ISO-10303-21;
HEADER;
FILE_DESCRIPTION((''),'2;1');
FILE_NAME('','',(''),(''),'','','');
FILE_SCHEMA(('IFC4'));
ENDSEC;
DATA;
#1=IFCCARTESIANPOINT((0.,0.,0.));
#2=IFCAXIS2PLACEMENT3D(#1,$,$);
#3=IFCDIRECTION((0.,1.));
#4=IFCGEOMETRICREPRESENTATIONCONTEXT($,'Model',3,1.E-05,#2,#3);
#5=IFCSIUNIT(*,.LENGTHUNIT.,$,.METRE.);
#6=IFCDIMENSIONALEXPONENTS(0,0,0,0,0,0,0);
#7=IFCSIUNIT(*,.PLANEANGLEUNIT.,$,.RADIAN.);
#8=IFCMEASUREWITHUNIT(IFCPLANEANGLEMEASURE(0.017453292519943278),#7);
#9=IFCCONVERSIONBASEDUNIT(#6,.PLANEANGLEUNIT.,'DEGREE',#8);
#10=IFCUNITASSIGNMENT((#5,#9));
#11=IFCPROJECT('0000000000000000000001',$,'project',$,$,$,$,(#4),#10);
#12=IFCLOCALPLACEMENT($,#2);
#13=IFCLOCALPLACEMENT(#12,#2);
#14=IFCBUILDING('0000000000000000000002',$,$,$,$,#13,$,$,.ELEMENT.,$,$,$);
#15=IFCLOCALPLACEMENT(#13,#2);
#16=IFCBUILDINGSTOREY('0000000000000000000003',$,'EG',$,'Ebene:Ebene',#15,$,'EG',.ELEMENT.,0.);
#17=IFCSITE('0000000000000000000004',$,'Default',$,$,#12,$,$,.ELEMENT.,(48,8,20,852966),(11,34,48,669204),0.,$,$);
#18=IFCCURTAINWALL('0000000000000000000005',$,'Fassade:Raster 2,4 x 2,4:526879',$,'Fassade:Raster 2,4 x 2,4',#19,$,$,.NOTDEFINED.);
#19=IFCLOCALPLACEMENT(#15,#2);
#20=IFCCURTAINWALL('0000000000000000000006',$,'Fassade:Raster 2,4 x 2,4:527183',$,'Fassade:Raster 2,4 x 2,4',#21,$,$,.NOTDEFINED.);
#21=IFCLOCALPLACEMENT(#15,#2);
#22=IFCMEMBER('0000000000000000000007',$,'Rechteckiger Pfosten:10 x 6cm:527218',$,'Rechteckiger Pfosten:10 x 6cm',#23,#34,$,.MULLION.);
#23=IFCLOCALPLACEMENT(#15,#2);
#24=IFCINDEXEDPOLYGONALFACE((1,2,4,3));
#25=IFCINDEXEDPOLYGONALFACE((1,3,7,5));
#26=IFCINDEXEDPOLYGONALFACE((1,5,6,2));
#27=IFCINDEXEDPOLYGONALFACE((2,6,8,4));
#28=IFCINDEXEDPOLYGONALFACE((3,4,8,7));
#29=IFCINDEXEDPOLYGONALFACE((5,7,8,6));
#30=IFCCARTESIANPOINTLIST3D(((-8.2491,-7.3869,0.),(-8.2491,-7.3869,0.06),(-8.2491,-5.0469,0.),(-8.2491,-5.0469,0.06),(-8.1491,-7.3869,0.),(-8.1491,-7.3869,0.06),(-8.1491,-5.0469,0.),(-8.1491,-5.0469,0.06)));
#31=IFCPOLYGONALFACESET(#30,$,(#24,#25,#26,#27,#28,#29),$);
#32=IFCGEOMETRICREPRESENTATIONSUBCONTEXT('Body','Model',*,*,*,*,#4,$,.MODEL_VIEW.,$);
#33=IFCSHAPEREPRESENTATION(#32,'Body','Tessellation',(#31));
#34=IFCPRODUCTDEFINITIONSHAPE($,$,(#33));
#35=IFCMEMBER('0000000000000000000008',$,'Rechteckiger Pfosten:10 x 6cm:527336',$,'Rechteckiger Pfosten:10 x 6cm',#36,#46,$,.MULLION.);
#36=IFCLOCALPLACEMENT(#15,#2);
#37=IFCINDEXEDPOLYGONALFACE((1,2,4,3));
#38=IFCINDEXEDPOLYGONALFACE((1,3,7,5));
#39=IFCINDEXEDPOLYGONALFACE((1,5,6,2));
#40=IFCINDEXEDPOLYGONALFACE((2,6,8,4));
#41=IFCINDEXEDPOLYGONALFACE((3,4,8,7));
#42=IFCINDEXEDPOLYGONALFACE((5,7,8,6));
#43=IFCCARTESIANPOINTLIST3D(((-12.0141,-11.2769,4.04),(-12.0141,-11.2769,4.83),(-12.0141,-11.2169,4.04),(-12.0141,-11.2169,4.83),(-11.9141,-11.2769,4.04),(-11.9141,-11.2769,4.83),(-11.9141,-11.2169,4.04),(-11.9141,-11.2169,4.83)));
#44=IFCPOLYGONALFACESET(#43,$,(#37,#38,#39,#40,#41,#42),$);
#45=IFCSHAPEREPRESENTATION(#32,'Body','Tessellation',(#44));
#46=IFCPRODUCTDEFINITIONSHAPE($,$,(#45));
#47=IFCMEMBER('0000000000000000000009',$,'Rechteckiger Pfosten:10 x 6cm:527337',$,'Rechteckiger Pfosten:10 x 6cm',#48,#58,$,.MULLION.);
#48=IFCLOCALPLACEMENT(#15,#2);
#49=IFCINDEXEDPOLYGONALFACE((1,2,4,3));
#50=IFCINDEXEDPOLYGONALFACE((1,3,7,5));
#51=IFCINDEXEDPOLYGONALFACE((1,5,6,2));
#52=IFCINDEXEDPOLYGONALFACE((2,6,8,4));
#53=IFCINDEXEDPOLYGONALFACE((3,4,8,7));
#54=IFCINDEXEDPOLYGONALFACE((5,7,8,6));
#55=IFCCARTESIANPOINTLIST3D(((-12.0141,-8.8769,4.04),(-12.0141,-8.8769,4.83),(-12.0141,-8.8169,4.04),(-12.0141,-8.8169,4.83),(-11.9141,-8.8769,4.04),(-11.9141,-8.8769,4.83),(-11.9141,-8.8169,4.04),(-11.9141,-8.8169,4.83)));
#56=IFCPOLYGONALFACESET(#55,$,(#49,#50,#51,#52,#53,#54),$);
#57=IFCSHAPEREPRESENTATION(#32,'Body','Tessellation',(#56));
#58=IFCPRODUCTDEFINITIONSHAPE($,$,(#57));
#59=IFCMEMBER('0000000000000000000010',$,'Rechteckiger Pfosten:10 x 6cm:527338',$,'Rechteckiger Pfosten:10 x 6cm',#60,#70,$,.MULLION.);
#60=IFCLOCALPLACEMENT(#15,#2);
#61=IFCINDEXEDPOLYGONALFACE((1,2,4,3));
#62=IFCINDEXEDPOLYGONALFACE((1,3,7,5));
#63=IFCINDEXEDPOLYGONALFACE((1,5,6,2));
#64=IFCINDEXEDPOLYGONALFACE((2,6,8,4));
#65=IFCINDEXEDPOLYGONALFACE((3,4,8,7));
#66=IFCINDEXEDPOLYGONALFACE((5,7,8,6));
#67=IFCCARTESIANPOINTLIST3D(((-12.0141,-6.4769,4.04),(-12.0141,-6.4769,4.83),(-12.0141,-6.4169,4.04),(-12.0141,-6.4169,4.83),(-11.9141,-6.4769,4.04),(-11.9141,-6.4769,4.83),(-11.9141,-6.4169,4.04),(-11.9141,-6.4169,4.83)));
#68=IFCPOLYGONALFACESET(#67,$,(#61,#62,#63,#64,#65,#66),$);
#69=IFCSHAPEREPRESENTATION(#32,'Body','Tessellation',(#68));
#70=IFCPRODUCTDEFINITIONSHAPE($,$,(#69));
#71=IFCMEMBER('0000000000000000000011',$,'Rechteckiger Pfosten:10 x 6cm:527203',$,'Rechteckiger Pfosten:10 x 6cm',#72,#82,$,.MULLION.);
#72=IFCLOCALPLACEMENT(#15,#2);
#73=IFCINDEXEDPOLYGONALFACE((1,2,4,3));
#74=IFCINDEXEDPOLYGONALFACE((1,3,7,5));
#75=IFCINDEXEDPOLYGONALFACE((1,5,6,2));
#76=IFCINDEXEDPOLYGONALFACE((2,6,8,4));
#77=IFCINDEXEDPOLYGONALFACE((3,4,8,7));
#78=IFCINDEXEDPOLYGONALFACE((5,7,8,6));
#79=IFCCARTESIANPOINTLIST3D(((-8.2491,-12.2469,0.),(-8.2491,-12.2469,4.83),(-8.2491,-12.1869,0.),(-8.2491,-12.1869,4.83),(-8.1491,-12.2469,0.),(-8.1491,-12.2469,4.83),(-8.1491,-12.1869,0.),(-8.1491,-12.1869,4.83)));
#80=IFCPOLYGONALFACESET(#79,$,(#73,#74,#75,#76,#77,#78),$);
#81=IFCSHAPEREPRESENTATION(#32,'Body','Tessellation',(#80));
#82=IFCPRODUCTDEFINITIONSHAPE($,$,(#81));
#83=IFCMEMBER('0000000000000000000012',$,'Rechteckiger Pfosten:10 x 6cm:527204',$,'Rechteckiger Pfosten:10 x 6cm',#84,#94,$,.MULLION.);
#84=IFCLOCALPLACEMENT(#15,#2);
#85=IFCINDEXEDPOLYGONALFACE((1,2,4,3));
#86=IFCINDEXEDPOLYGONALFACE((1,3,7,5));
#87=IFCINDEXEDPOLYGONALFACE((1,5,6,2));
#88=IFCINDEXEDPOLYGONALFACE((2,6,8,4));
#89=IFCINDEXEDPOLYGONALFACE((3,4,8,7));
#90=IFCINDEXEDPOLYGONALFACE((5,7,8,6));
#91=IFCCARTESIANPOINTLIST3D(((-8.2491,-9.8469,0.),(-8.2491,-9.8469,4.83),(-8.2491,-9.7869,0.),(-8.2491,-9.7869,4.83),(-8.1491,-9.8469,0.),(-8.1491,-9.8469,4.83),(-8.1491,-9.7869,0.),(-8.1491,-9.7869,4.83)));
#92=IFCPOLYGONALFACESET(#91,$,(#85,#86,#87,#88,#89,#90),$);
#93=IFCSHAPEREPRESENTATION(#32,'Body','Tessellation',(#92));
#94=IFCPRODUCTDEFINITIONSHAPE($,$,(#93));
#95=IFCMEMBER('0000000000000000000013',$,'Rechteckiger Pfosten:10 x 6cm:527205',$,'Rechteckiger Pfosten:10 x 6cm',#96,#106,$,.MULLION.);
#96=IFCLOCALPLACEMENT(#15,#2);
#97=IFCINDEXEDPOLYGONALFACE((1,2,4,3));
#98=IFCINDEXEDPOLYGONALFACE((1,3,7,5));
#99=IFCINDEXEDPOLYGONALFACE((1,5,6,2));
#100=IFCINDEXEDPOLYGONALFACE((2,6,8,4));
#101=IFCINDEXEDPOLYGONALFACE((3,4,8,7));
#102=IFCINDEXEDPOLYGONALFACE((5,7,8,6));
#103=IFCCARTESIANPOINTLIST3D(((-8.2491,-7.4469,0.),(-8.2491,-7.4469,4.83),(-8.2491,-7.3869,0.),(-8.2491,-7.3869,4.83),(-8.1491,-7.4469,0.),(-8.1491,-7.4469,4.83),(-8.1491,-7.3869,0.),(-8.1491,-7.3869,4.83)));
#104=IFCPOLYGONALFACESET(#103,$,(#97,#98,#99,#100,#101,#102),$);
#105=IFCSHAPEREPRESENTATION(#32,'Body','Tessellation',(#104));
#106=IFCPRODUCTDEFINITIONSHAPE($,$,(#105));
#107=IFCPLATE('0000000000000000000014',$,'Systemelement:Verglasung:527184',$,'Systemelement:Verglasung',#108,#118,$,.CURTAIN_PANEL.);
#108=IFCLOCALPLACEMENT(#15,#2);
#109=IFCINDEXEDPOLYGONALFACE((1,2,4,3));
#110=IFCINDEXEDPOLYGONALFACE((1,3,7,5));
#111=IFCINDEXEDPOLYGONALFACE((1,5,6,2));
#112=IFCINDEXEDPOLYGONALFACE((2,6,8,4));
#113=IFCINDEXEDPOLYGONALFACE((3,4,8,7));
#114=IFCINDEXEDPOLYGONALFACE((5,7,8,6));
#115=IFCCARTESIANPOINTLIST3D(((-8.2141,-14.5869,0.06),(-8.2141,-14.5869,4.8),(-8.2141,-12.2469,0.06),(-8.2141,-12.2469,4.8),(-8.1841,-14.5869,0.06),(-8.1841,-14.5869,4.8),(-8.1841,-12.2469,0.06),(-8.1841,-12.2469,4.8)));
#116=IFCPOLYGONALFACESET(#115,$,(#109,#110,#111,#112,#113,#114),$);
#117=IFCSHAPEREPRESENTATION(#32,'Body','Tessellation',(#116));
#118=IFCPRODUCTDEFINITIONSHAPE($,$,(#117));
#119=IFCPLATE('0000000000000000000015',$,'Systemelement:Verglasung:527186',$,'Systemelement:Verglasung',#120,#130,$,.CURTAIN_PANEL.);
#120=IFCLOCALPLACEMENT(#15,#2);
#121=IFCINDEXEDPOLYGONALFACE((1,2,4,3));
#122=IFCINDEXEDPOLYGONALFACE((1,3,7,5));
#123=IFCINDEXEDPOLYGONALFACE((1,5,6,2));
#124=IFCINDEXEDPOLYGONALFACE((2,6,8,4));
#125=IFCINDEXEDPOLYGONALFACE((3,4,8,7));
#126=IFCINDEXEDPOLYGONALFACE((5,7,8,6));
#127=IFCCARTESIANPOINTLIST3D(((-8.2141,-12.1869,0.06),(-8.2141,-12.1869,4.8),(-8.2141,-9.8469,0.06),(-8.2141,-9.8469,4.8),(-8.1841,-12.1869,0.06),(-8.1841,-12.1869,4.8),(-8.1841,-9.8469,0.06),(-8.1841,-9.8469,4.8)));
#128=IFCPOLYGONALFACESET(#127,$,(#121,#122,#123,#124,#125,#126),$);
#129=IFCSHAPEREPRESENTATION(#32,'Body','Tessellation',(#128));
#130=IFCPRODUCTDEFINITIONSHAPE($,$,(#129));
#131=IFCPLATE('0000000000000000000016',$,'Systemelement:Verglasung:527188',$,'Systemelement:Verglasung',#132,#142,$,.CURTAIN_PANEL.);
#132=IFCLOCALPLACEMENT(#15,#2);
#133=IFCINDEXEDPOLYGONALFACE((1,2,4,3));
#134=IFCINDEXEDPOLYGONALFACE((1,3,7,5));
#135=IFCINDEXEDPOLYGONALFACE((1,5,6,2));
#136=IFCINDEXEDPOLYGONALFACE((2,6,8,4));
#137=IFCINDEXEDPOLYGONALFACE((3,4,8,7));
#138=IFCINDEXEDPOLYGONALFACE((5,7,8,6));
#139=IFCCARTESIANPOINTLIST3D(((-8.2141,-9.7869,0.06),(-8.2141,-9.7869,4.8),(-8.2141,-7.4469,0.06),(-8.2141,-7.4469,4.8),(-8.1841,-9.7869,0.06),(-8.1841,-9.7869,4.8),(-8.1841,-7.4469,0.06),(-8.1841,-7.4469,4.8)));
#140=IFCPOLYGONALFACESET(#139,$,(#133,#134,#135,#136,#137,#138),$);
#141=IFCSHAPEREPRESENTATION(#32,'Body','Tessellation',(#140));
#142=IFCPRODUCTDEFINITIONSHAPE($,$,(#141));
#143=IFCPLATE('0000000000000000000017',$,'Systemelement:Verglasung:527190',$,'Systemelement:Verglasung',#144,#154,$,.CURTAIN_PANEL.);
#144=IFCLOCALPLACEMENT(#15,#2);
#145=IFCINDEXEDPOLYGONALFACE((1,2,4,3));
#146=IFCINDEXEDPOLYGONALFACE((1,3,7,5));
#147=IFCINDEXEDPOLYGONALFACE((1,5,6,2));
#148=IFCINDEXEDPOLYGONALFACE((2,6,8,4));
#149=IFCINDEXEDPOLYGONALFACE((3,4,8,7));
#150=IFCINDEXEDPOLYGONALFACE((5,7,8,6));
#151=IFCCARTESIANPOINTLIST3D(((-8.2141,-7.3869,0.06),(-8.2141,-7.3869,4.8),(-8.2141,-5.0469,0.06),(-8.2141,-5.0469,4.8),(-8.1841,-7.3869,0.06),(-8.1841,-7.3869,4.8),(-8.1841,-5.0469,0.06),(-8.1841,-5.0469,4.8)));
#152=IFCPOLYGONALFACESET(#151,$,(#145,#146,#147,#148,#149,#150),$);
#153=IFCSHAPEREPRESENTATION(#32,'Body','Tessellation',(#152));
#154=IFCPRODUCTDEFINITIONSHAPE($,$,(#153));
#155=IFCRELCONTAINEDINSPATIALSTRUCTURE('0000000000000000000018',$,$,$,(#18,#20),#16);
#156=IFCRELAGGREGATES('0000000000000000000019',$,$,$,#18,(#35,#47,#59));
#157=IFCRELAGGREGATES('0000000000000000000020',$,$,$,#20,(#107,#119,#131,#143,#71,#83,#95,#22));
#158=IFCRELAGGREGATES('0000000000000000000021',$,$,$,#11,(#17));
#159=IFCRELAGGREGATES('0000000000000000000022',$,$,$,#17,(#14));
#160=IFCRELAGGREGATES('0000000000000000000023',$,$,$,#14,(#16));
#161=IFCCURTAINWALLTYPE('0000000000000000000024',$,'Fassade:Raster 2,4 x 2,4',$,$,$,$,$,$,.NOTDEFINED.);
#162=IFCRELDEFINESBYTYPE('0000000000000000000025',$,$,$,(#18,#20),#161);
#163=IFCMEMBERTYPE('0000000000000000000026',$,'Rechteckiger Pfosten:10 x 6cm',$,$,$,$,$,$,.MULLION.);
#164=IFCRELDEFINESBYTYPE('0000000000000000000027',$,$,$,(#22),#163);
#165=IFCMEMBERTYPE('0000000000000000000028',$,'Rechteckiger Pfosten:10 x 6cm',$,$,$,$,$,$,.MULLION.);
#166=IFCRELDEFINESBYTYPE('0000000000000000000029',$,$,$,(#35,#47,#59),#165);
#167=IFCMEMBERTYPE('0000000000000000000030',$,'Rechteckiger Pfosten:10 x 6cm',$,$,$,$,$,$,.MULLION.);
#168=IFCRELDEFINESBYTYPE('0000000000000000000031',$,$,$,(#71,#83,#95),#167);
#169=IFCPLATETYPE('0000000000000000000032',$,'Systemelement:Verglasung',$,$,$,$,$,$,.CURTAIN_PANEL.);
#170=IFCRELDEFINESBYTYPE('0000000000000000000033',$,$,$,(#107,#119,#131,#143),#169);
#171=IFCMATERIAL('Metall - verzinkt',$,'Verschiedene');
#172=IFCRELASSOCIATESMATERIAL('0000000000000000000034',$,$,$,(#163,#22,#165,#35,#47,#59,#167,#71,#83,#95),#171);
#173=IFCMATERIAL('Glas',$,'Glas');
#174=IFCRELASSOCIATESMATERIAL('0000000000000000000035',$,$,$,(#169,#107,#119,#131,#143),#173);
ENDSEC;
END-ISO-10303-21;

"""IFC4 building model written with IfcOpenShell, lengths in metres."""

from ifc_helpers import new_model, entity, si_unit, converted_unit, direction, frame, origin, place, context, subcontext, project, spatial, indexed_curve, outline, extrude, source, transform, mapped, material, type_object, type_shapes, element, aggregate, save


model = new_model("IFC4")

# Units and contexts
model_context = context("Model", 3, precision=1e-05, world=origin(), true_north=direction((0.0, 1.0)))
body_context = subcontext(model_context, "Body", "Model", "MODEL_VIEW")
ifc_project = project(units=[si_unit("LENGTHUNIT", "METRE"), converted_unit("PLANEANGLEUNIT", "DEGREE", entity("IfcPlaneAngleMeasure", 0.017453292519943278), si_unit("PLANEANGLEUNIT", "RADIAN"), dimensions=[0, 0, 0, 0, 0, 0, 0])], contexts=[model_context])

# Site, building, storey
site_placement = place(None, origin())
site = spatial("IfcSite", under=ifc_project, at=site_placement, Name="Default", CompositionType="ELEMENT", RefLatitude=(48, 8, 20, 852966), RefLongitude=(11, 34, 48, 669204), RefElevation=0.0)
building_placement = place(site_placement, origin())
building = spatial("IfcBuilding", under=site, at=building_placement, CompositionType="ELEMENT")
storey_placement = place(building_placement, origin())
storey = spatial("IfcBuildingStorey", under=building, at=storey_placement, Name="EG", ObjectType="Ebene:Ebene", LongName="EG", CompositionType="ELEMENT", Elevation=0.0)

# Curtain walls, member
curtain_wall_type = type_object("IfcCurtainWallType", Name="Fassade:Raster 2,4 x 2,4", PredefinedType="NOTDEFINED")
curtain_wall_1_placement = place(storey_placement, origin())
curtain_wall_1 = element("IfcCurtainWall", 1, at=curtain_wall_1_placement, inside=storey, type_object=curtain_wall_type, Name="Fassade:Raster 2,4 x 2,4:526879", ObjectType="Fassade:Raster 2,4 x 2,4", PredefinedType="NOTDEFINED")
ifc_material_1 = material(Name="Metall - verzinkt", Category="Verschiedene")
member_type_1 = type_object("IfcMemberType", Name="Rechteckiger Pfosten:10 x 6cm", PredefinedType="MULLION", material=ifc_material_1)
shared_shape_1 = source(origin(), body_context, "Body", "SweptSolid", [
    extrude(outline(indexed_curve([(-0.03, -0.05), (0.03, -0.05), (0.03, 0.05), (-0.03, 0.05), (-0.03, -0.05)], self_intersect=False)), frame((-0.03, 0.0, -2.34), z_axis=(0.0, 0.0, 1.0), x_axis=(-1.0, 0.0, 0.0)), (0.0, 0.0, 1.0), 2.34),
])
type_shapes(member_type_1, [shared_shape_1])
curtain_wall_2_placement = place(storey_placement, origin())
curtain_wall_2 = element("IfcCurtainWall", 2, at=curtain_wall_2_placement, inside=storey, type_object=curtain_wall_type, Name="Fassade:Raster 2,4 x 2,4:527183", ObjectType="Fassade:Raster 2,4 x 2,4", PredefinedType="NOTDEFINED")
member_1_placement = place(curtain_wall_2_placement, frame((-8.1991, -7.3869, 0.0), z_axis=(0.0, -1.0, 0.0), x_axis=(0.0, 0.0, -1.0)))
member_1 = element("IfcMember", 3, at=member_1_placement, type_object=member_type_1, material=ifc_material_1, Name="Rechteckiger Pfosten:10 x 6cm:527218", ObjectType="Rechteckiger Pfosten:10 x 6cm", PredefinedType="MULLION", context=body_context, shape_type="MappedRepresentation", body=[
    mapped(shared_shape_1, transform((0.0, 0.0, 0.0), scale=1.0)),
])

# Members
member_type_2 = type_object("IfcMemberType", Name="Rechteckiger Pfosten:10 x 6cm", PredefinedType="MULLION", material=ifc_material_1)
shared_shape_2 = source(origin(), body_context, "Body", "SweptSolid", [
    extrude(outline(indexed_curve([(-0.03, -0.05), (0.03, -0.05), (0.03, 0.05), (-0.03, 0.05), (-0.03, -0.05)], self_intersect=False)), frame((0.0, 0.0, -0.79), z_axis=(0.0, 0.0, 1.0), x_axis=(-1.0, 0.0, 0.0)), (0.0, 0.0, 1.0), 0.79),
])
type_shapes(member_type_2, [shared_shape_2])
member_2_placement = place(curtain_wall_1_placement, frame((-11.9641, -11.2469, 4.04), z_axis=(0.0, 0.0, -1.0), x_axis=(0.0, 1.0, 0.0)))
member_2 = element("IfcMember", 4, at=member_2_placement, type_object=member_type_2, material=ifc_material_1, Name="Rechteckiger Pfosten:10 x 6cm:527336", ObjectType="Rechteckiger Pfosten:10 x 6cm", PredefinedType="MULLION", context=body_context, shape_type="MappedRepresentation", body=[
    mapped(shared_shape_2, transform((0.0, 0.0, 0.0), scale=1.0)),
])
member_3_placement = place(curtain_wall_1_placement, frame((-11.9641, -8.8469, 4.04), z_axis=(0.0, 0.0, -1.0), x_axis=(0.0, 1.0, 0.0)))
member_3 = element("IfcMember", 5, at=member_3_placement, type_object=member_type_2, material=ifc_material_1, Name="Rechteckiger Pfosten:10 x 6cm:527337", ObjectType="Rechteckiger Pfosten:10 x 6cm", PredefinedType="MULLION", context=body_context, shape_type="MappedRepresentation", body=[
    mapped(shared_shape_2, transform((0.0, 0.0, 0.0), scale=1.0)),
])
member_4_placement = place(curtain_wall_1_placement, frame((-11.9641, -6.4469, 4.04), z_axis=(0.0, 0.0, -1.0), x_axis=(0.0, 1.0, 0.0)))
member_4 = element("IfcMember", 6, at=member_4_placement, type_object=member_type_2, material=ifc_material_1, Name="Rechteckiger Pfosten:10 x 6cm:527338", ObjectType="Rechteckiger Pfosten:10 x 6cm", PredefinedType="MULLION", context=body_context, shape_type="MappedRepresentation", body=[
    mapped(shared_shape_2, transform((0.0, 0.0, 0.0), scale=1.0)),
])
member_type_3 = type_object("IfcMemberType", Name="Rechteckiger Pfosten:10 x 6cm", PredefinedType="MULLION", material=ifc_material_1)
shared_shape_3 = source(origin(), body_context, "Body", "SweptSolid", [
    extrude(outline(indexed_curve([(-0.03, -0.05), (0.03, -0.05), (0.03, 0.05), (-0.03, 0.05), (-0.03, -0.05)], self_intersect=False)), frame((0.0, 0.0, -4.83), z_axis=(0.0, 0.0, 1.0), x_axis=(-1.0, 0.0, 0.0)), (0.0, 0.0, 1.0), 4.83),
])
type_shapes(member_type_3, [shared_shape_3])
member_5_placement = place(curtain_wall_2_placement, frame((-8.1991, -12.2169, 0.0), z_axis=(0.0, 0.0, -1.0), x_axis=(0.0, 1.0, 0.0)))
member_5 = element("IfcMember", 7, at=member_5_placement, type_object=member_type_3, material=ifc_material_1, Name="Rechteckiger Pfosten:10 x 6cm:527203", ObjectType="Rechteckiger Pfosten:10 x 6cm", PredefinedType="MULLION", context=body_context, shape_type="MappedRepresentation", body=[
    mapped(shared_shape_3, transform((0.0, 0.0, 0.0), scale=1.0)),
])
member_6_placement = place(curtain_wall_2_placement, frame((-8.1991, -9.8169, 0.0), z_axis=(0.0, 0.0, -1.0), x_axis=(0.0, 1.0, 0.0)))
member_6 = element("IfcMember", 8, at=member_6_placement, type_object=member_type_3, material=ifc_material_1, Name="Rechteckiger Pfosten:10 x 6cm:527204", ObjectType="Rechteckiger Pfosten:10 x 6cm", PredefinedType="MULLION", context=body_context, shape_type="MappedRepresentation", body=[
    mapped(shared_shape_3, transform((0.0, 0.0, 0.0), scale=1.0)),
])
member_7_placement = place(curtain_wall_2_placement, frame((-8.1991, -7.4169, 0.0), z_axis=(0.0, 0.0, -1.0), x_axis=(0.0, 1.0, 0.0)))
member_7 = element("IfcMember", 9, at=member_7_placement, type_object=member_type_3, material=ifc_material_1, Name="Rechteckiger Pfosten:10 x 6cm:527205", ObjectType="Rechteckiger Pfosten:10 x 6cm", PredefinedType="MULLION", context=body_context, shape_type="MappedRepresentation", body=[
    mapped(shared_shape_3, transform((0.0, 0.0, 0.0), scale=1.0)),
])

# Plates
ifc_material_2 = material(Name="Glas", Category="Glas")
aggregate(curtain_wall_1, [member_2, member_3, member_4])
plate_type_1 = type_object("IfcPlateType", Name="Systemelement:Verglasung", PredefinedType="CURTAIN_PANEL", material=ifc_material_2)
shared_shape_4 = source(origin(), body_context, "Body", "SweptSolid", [
    extrude(outline(indexed_curve([(-0.015, -1.17), (0.015, -1.17), (0.015, 1.17), (-0.015, 1.17), (-0.015, -1.17)], self_intersect=False)), frame((0.0, 0.0, 0.0), z_axis=(0.0, 0.0, 1.0), x_axis=(0.0, 1.0, 0.0)), (0.0, 0.0, 1.0), 4.74),
])
type_shapes(plate_type_1, [shared_shape_4])
plate_1_placement = place(curtain_wall_2_placement, frame((-8.1991, -13.4169, 0.06), z_axis=(0.0, 0.0, 1.0), x_axis=(0.0, 1.0, 0.0)))
plate_1 = element("IfcPlate", 10, at=plate_1_placement, type_object=plate_type_1, material=ifc_material_2, Name="Systemelement:Verglasung:527184", ObjectType="Systemelement:Verglasung", PredefinedType="CURTAIN_PANEL", context=body_context, shape_type="MappedRepresentation", body=[
    mapped(shared_shape_4, transform((0.0, 0.0, 0.0), scale=1.0)),
])
plate_2_placement = place(curtain_wall_2_placement, frame((-8.1991, -11.0169, 0.06), z_axis=(0.0, 0.0, 1.0), x_axis=(0.0, 1.0, 0.0)))
plate_2 = element("IfcPlate", 11, at=plate_2_placement, type_object=plate_type_1, material=ifc_material_2, Name="Systemelement:Verglasung:527186", ObjectType="Systemelement:Verglasung", PredefinedType="CURTAIN_PANEL", context=body_context, shape_type="MappedRepresentation", body=[
    mapped(shared_shape_4, transform((0.0, 0.0, 0.0), scale=1.0)),
])
plate_3_placement = place(curtain_wall_2_placement, frame((-8.1991, -8.6169, 0.06), z_axis=(0.0, 0.0, 1.0), x_axis=(0.0, 1.0, 0.0)))
plate_3 = element("IfcPlate", 12, at=plate_3_placement, type_object=plate_type_1, material=ifc_material_2, Name="Systemelement:Verglasung:527188", ObjectType="Systemelement:Verglasung", PredefinedType="CURTAIN_PANEL", context=body_context, shape_type="MappedRepresentation", body=[
    mapped(shared_shape_4, transform((0.0, 0.0, 0.0), scale=1.0)),
])
plate_4_placement = place(curtain_wall_2_placement, frame((-8.1991, -6.2169, 0.06), z_axis=(0.0, 0.0, 1.0), x_axis=(0.0, 1.0, 0.0)))
plate_4 = element("IfcPlate", 13, at=plate_4_placement, type_object=plate_type_1, material=ifc_material_2, Name="Systemelement:Verglasung:527190", ObjectType="Systemelement:Verglasung", PredefinedType="CURTAIN_PANEL", context=body_context, shape_type="MappedRepresentation", body=[
    mapped(shared_shape_4, transform((0.0, 0.0, 0.0), scale=1.0)),
])
aggregate(curtain_wall_2, [plate_1, plate_2, plate_3, plate_4, member_5, member_6, member_7, member_1])

save(model, "model.ifc")
